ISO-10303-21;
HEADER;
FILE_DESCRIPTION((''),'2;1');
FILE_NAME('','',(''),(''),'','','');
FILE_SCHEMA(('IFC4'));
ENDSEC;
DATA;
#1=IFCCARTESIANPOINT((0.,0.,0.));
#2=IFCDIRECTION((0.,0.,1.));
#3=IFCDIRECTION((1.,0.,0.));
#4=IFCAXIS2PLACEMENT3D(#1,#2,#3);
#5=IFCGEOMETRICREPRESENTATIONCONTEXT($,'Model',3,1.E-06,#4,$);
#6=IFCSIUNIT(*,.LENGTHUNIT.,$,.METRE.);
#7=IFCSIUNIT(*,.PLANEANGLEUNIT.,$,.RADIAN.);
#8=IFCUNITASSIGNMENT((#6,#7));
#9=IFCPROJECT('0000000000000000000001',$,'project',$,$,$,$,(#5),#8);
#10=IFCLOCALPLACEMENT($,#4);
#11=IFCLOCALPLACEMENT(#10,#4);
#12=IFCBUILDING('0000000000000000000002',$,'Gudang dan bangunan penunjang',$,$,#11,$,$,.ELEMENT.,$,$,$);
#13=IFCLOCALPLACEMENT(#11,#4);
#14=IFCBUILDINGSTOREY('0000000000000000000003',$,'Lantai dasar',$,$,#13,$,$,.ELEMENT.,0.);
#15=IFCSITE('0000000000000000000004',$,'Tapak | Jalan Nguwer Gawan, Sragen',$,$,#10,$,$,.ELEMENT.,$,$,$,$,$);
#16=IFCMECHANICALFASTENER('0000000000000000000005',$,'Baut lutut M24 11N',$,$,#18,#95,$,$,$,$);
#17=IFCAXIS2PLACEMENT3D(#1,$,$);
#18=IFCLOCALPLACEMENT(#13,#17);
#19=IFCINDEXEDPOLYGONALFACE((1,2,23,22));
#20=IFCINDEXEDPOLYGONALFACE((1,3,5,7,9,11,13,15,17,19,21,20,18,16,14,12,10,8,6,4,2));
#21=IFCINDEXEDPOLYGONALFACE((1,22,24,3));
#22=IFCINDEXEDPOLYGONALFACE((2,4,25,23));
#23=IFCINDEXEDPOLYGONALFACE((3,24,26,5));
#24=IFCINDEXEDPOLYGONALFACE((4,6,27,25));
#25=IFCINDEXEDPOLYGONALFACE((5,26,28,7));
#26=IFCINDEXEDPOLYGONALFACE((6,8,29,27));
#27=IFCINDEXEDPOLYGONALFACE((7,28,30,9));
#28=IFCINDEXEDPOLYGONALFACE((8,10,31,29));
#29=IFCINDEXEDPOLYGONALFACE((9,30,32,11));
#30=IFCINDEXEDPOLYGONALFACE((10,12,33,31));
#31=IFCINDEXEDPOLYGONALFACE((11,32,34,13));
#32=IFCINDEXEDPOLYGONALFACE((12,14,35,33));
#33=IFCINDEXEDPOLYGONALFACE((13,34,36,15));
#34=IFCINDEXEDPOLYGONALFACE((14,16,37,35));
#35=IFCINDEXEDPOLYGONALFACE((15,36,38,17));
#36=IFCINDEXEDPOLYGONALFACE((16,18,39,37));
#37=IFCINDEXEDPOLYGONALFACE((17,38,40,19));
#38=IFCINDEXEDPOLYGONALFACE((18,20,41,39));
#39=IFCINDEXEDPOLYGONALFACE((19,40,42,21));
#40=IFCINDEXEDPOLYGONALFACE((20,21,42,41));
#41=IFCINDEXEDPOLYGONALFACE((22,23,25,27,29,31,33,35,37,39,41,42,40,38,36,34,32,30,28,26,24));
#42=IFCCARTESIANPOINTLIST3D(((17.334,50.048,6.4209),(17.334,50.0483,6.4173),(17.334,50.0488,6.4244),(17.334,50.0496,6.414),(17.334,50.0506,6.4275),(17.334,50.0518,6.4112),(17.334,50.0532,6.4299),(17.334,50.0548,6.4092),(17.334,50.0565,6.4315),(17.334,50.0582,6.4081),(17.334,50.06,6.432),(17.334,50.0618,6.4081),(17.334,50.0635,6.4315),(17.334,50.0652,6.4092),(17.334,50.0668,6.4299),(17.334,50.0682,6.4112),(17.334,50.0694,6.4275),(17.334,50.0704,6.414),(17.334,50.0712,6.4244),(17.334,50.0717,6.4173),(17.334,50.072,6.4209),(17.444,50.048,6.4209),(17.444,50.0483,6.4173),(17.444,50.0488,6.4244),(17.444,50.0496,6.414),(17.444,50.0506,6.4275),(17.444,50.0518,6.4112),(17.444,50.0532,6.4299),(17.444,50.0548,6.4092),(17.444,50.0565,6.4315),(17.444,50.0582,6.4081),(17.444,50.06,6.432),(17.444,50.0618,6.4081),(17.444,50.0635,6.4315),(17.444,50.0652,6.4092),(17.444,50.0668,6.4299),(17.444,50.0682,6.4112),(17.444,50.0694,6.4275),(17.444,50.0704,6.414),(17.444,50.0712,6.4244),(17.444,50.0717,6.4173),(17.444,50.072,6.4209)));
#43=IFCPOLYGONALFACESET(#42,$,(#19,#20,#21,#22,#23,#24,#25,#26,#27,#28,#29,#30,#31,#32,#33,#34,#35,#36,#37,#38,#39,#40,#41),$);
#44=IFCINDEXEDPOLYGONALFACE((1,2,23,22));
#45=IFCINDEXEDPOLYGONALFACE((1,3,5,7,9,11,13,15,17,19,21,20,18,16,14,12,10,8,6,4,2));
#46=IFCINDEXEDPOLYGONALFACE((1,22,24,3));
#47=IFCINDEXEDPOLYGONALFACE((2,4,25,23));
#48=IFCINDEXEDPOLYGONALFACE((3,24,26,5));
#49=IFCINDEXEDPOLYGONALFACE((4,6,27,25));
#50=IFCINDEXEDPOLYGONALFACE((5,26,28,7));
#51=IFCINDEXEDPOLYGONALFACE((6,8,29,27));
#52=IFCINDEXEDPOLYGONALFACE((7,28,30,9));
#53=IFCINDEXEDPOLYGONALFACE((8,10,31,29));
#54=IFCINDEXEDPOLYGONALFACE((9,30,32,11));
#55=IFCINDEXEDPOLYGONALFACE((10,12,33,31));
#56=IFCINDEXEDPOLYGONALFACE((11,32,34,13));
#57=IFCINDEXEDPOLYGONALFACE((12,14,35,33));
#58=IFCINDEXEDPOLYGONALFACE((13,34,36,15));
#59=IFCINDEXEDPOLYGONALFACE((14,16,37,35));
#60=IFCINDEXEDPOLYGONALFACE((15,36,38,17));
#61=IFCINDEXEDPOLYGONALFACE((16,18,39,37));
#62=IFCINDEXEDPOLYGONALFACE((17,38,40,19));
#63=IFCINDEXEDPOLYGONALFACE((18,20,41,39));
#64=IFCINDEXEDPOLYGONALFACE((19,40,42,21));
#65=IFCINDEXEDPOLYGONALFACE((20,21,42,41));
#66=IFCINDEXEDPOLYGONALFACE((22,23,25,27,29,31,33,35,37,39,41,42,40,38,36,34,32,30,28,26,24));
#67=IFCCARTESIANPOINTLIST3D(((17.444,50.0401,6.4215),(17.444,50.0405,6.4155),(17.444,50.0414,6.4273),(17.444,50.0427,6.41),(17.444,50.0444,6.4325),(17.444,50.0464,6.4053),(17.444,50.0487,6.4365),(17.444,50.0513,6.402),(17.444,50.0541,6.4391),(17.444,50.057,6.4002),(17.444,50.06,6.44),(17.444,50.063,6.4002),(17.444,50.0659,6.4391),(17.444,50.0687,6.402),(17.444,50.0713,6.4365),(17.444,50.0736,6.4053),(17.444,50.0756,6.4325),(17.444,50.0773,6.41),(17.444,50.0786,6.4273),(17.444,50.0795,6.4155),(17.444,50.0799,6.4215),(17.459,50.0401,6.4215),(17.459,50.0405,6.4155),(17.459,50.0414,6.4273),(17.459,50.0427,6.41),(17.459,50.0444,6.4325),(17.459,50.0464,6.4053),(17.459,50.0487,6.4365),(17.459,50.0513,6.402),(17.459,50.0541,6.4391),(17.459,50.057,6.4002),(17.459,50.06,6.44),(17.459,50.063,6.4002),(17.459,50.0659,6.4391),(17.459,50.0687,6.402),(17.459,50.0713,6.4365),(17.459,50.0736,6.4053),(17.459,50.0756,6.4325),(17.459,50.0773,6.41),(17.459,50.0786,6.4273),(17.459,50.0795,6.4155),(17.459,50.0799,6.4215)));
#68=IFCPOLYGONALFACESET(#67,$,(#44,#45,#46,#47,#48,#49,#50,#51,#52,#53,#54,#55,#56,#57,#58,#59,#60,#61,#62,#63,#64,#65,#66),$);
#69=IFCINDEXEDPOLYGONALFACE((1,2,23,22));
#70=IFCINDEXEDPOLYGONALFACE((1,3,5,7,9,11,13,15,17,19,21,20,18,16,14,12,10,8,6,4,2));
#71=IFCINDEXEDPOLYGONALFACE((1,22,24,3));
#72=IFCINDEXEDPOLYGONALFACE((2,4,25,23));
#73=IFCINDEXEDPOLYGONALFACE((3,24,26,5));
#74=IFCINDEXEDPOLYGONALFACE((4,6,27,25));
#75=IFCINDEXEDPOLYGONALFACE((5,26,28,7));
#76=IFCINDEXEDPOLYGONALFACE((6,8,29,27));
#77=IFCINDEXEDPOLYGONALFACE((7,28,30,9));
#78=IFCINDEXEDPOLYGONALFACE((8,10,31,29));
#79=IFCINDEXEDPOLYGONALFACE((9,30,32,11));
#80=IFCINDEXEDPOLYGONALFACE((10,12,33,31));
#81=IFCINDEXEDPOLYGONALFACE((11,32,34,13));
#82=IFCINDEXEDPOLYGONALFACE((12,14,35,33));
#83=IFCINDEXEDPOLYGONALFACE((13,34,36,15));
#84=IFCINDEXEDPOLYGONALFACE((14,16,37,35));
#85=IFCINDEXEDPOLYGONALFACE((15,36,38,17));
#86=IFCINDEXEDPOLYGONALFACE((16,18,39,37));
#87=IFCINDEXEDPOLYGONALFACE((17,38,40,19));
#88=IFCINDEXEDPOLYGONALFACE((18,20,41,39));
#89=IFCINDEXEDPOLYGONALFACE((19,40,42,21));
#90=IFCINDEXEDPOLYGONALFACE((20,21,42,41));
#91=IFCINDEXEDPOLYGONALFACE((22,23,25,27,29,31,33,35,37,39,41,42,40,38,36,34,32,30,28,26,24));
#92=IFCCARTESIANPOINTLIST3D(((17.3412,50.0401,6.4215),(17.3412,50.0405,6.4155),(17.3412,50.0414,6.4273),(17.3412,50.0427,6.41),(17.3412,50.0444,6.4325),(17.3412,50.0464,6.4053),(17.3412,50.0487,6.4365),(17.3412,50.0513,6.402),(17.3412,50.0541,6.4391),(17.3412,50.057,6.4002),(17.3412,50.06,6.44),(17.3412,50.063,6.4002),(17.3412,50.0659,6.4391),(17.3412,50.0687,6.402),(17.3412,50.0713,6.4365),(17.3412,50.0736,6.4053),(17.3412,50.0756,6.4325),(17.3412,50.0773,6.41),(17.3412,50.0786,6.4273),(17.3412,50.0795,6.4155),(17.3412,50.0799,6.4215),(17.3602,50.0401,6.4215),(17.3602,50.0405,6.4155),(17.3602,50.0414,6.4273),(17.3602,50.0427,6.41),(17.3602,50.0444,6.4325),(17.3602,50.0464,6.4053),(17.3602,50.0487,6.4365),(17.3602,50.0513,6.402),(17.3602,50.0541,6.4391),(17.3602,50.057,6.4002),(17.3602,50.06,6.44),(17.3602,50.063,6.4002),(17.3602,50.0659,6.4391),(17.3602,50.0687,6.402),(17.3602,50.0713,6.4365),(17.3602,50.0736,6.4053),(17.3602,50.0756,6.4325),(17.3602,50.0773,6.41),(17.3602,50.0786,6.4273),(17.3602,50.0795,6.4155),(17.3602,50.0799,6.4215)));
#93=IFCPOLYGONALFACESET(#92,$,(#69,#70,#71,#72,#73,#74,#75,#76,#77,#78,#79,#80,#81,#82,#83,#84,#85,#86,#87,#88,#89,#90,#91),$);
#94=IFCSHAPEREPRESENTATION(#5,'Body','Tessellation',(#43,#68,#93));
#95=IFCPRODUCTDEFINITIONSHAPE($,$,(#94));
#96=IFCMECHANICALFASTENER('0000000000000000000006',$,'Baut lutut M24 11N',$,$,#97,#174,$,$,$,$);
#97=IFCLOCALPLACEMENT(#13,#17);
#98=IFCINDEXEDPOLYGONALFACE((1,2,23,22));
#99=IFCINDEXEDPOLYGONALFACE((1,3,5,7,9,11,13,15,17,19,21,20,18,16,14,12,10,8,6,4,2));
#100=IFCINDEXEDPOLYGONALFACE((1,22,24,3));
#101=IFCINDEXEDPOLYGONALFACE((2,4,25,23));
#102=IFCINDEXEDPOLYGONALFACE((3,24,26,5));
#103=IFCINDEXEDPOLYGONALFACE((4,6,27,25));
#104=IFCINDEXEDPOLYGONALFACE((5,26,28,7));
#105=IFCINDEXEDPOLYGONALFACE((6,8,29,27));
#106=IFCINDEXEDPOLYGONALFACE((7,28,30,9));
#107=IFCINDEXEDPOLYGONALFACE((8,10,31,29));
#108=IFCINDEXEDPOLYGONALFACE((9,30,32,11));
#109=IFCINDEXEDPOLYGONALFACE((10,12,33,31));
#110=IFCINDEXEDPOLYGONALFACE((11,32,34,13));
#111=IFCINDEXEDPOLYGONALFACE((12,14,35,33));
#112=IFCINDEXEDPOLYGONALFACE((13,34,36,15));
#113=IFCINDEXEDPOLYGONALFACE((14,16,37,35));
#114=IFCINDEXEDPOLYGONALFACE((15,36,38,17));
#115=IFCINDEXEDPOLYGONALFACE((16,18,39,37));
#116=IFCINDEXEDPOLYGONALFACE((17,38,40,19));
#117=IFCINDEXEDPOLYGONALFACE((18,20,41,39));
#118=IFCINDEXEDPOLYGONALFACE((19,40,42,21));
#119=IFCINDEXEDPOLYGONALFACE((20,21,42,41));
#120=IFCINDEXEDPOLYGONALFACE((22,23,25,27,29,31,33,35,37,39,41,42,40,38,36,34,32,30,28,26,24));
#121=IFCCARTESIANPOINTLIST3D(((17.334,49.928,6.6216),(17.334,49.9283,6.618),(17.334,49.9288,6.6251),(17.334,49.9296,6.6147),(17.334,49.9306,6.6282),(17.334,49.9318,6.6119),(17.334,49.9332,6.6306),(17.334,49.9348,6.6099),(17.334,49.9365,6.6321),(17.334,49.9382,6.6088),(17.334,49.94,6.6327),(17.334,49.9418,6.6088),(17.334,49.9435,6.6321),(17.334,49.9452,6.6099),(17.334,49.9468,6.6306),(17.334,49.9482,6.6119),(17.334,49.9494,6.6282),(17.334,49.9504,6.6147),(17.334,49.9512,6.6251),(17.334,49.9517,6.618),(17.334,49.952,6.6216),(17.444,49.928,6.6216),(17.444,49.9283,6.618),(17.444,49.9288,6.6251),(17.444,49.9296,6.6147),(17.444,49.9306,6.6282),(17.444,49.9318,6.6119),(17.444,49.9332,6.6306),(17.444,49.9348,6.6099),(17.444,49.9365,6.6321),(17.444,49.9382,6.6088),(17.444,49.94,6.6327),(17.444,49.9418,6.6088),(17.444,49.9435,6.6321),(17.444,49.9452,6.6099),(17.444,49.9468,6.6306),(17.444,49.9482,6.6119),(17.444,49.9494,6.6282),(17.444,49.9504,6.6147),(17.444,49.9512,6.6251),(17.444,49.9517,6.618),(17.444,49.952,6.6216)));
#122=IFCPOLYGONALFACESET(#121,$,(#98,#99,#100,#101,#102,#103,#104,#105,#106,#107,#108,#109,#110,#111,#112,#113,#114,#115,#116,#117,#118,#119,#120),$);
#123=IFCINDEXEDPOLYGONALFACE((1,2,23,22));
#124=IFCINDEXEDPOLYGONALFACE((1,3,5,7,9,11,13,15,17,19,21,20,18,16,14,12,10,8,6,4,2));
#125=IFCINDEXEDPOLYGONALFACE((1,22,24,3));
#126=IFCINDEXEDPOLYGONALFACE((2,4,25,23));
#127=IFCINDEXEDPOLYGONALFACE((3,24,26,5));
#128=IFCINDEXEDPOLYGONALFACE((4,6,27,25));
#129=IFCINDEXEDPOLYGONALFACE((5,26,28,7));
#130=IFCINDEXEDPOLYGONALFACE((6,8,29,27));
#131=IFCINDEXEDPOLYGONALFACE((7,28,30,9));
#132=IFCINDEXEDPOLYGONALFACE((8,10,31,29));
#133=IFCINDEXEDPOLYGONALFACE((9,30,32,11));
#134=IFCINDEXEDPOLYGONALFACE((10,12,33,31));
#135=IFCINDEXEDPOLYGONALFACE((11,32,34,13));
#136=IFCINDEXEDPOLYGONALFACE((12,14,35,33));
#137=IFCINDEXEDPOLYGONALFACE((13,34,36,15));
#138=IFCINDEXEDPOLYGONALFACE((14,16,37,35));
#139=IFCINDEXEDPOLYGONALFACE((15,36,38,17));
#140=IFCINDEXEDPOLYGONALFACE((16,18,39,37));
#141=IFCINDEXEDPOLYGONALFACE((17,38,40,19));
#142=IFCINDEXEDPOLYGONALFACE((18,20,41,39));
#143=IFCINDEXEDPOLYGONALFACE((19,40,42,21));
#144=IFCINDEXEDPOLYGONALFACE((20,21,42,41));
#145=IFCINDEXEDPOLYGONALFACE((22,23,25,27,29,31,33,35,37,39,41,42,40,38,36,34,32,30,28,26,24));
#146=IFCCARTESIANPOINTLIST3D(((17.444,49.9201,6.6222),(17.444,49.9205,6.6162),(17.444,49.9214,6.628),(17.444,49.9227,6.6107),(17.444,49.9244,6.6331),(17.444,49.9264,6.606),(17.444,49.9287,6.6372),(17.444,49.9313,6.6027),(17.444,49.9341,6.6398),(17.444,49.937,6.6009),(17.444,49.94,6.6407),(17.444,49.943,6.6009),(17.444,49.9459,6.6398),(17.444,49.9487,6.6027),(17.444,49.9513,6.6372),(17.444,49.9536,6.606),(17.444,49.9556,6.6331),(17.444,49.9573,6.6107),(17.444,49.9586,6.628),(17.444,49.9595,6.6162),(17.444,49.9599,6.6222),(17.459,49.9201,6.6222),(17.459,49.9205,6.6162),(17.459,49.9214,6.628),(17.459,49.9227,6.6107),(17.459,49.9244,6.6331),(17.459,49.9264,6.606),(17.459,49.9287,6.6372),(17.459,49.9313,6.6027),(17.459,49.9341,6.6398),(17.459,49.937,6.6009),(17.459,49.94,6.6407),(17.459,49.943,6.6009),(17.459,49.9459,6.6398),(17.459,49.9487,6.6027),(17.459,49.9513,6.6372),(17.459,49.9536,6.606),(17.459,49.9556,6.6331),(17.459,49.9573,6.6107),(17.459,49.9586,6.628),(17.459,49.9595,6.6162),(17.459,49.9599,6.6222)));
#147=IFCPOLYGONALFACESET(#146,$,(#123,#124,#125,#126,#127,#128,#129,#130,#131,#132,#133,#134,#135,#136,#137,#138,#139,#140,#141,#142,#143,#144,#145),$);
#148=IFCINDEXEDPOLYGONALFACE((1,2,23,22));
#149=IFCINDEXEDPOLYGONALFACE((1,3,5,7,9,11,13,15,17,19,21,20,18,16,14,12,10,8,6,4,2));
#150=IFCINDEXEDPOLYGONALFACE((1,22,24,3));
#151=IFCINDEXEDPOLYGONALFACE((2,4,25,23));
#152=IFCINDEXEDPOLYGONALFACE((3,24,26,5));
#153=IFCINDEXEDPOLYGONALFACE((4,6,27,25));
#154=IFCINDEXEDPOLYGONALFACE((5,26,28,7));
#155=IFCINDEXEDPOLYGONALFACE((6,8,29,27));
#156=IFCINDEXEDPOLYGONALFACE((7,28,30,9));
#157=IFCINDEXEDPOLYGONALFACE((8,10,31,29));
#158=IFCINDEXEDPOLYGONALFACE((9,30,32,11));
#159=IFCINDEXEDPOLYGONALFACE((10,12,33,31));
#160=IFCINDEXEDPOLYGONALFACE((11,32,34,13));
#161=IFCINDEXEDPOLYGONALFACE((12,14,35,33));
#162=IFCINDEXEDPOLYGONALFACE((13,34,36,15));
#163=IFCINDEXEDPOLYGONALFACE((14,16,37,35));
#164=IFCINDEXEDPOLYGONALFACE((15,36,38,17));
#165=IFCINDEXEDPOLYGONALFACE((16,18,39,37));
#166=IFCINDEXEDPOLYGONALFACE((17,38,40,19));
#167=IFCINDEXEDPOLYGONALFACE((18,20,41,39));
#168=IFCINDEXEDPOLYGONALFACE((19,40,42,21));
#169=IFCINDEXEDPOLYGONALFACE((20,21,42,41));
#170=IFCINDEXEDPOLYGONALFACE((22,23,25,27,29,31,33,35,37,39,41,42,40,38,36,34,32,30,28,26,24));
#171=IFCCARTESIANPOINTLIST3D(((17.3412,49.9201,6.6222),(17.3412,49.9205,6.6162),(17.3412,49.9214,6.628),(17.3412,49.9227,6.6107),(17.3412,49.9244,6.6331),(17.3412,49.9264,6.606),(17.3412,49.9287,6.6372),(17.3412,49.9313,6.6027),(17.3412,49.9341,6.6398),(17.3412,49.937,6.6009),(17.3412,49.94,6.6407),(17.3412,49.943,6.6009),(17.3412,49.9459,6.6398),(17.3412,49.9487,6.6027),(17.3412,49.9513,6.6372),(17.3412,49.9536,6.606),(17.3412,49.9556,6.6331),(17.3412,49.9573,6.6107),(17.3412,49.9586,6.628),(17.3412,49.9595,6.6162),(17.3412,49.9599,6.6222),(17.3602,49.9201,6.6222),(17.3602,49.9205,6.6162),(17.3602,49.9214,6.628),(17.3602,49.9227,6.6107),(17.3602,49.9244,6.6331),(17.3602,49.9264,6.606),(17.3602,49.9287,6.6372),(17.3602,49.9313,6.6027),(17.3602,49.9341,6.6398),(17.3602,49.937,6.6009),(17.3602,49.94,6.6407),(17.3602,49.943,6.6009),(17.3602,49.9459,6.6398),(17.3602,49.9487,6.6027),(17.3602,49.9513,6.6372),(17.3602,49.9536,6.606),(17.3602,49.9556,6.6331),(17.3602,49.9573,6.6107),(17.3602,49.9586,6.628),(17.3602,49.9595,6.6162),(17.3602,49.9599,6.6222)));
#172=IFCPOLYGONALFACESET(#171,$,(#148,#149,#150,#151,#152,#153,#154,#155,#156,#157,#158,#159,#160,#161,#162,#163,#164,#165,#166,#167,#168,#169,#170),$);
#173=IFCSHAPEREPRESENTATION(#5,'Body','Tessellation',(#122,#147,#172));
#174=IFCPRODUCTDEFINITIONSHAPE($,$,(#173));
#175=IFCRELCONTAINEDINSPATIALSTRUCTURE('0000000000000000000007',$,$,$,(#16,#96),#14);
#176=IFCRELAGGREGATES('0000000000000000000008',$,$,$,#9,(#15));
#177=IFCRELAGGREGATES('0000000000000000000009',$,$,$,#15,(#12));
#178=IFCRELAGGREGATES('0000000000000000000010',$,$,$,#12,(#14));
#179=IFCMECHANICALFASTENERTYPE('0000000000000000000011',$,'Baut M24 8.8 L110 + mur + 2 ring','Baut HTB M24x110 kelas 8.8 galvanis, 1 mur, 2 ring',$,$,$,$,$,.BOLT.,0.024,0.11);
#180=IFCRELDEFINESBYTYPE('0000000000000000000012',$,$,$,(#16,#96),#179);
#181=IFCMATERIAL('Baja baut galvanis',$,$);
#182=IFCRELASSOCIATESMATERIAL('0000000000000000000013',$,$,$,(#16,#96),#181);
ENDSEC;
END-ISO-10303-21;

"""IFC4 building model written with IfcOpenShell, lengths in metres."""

from ifc_helpers import new_model, si_unit, frame, origin_with_axes, place, context, project, spatial, circle, extrude, source, transform, mapped, material, type_object, type_shapes, element, save


model = new_model("IFC4")

# Units and contexts
model_context = context("Model", 3, precision=1e-06, world=origin_with_axes())
ifc_project = project(units=[si_unit("LENGTHUNIT", "METRE"), si_unit("PLANEANGLEUNIT", "RADIAN")], contexts=[model_context])

# Site, building, storey
site_placement = place(None, origin_with_axes())
site = spatial("IfcSite", under=ifc_project, at=site_placement, Name="Tapak | Jalan Nguwer Gawan, Sragen", CompositionType="ELEMENT")
building_placement = place(site_placement, origin_with_axes())
building = spatial("IfcBuilding", under=site, at=building_placement, Name="Gudang dan bangunan penunjang", CompositionType="ELEMENT")
storey_placement = place(building_placement, origin_with_axes())
storey = spatial("IfcBuildingStorey", under=building, at=storey_placement, Name="Lantai dasar", CompositionType="ELEMENT", Elevation=0.0)

# Shared definitions
placement = place(None, origin_with_axes())

# Mechanical fasteners
ifc_material_1 = material(Name="Baja baut galvanis")
mechanical_fastener_type_1 = type_object("IfcMechanicalFastenerType", Name="Baut M24 8.8 L110 + mur + 2 ring", Description="Baut HTB M24x110 kelas 8.8 galvanis, 1 mur, 2 ring", NominalDiameter=0.024, NominalLength=0.11, PredefinedType="BOLT")
shared_shape_1 = source(origin_with_axes(), model_context, "Body", "SweptSolid", [
    extrude(circle(Radius=0.012), origin_with_axes(), (0.0, 0.0, 1.0), 0.11),
    extrude(circle(Radius=0.02), frame((0.0, 0.0, -0.015), z_axis=(0.0, 0.0, 1.0), x_axis=(1.0, 0.0, 0.0)), (0.0, 0.0, 1.0), 0.015),
    extrude(circle(Radius=0.02), frame((0.0, 0.0, 0.0838), z_axis=(0.0, 0.0, 1.0), x_axis=(1.0, 0.0, 0.0)), (0.0, 0.0, 1.0), 0.019),
])
type_shapes(mechanical_fastener_type_1, [shared_shape_1])
element("IfcMechanicalFastener", 1, at=placement, inside=storey, type_object=mechanical_fastener_type_1, material=ifc_material_1, Name="Baut lutut M24 11N", context=model_context, shape_type="MappedRepresentation", body=[
    mapped(shared_shape_1, transform((17.444, 50.06, 6.42), x_axis=(0.0, 0.0, 1.0), y_axis=(0.0, 1.0, 0.0), z_axis=(-1.0, 0.0, 0.0), scale=1.0)),
])
element("IfcMechanicalFastener", 2, at=placement, inside=storey, type_object=mechanical_fastener_type_1, material=ifc_material_1, Name="Baut lutut M24 11N", context=model_context, shape_type="MappedRepresentation", body=[
    mapped(shared_shape_1, transform((17.444, 49.94, 6.6207), x_axis=(0.0, 0.0, 1.0), y_axis=(0.0, 1.0, 0.0), z_axis=(-1.0, 0.0, 0.0), scale=1.0)),
])

save(model, "model.ifc")
